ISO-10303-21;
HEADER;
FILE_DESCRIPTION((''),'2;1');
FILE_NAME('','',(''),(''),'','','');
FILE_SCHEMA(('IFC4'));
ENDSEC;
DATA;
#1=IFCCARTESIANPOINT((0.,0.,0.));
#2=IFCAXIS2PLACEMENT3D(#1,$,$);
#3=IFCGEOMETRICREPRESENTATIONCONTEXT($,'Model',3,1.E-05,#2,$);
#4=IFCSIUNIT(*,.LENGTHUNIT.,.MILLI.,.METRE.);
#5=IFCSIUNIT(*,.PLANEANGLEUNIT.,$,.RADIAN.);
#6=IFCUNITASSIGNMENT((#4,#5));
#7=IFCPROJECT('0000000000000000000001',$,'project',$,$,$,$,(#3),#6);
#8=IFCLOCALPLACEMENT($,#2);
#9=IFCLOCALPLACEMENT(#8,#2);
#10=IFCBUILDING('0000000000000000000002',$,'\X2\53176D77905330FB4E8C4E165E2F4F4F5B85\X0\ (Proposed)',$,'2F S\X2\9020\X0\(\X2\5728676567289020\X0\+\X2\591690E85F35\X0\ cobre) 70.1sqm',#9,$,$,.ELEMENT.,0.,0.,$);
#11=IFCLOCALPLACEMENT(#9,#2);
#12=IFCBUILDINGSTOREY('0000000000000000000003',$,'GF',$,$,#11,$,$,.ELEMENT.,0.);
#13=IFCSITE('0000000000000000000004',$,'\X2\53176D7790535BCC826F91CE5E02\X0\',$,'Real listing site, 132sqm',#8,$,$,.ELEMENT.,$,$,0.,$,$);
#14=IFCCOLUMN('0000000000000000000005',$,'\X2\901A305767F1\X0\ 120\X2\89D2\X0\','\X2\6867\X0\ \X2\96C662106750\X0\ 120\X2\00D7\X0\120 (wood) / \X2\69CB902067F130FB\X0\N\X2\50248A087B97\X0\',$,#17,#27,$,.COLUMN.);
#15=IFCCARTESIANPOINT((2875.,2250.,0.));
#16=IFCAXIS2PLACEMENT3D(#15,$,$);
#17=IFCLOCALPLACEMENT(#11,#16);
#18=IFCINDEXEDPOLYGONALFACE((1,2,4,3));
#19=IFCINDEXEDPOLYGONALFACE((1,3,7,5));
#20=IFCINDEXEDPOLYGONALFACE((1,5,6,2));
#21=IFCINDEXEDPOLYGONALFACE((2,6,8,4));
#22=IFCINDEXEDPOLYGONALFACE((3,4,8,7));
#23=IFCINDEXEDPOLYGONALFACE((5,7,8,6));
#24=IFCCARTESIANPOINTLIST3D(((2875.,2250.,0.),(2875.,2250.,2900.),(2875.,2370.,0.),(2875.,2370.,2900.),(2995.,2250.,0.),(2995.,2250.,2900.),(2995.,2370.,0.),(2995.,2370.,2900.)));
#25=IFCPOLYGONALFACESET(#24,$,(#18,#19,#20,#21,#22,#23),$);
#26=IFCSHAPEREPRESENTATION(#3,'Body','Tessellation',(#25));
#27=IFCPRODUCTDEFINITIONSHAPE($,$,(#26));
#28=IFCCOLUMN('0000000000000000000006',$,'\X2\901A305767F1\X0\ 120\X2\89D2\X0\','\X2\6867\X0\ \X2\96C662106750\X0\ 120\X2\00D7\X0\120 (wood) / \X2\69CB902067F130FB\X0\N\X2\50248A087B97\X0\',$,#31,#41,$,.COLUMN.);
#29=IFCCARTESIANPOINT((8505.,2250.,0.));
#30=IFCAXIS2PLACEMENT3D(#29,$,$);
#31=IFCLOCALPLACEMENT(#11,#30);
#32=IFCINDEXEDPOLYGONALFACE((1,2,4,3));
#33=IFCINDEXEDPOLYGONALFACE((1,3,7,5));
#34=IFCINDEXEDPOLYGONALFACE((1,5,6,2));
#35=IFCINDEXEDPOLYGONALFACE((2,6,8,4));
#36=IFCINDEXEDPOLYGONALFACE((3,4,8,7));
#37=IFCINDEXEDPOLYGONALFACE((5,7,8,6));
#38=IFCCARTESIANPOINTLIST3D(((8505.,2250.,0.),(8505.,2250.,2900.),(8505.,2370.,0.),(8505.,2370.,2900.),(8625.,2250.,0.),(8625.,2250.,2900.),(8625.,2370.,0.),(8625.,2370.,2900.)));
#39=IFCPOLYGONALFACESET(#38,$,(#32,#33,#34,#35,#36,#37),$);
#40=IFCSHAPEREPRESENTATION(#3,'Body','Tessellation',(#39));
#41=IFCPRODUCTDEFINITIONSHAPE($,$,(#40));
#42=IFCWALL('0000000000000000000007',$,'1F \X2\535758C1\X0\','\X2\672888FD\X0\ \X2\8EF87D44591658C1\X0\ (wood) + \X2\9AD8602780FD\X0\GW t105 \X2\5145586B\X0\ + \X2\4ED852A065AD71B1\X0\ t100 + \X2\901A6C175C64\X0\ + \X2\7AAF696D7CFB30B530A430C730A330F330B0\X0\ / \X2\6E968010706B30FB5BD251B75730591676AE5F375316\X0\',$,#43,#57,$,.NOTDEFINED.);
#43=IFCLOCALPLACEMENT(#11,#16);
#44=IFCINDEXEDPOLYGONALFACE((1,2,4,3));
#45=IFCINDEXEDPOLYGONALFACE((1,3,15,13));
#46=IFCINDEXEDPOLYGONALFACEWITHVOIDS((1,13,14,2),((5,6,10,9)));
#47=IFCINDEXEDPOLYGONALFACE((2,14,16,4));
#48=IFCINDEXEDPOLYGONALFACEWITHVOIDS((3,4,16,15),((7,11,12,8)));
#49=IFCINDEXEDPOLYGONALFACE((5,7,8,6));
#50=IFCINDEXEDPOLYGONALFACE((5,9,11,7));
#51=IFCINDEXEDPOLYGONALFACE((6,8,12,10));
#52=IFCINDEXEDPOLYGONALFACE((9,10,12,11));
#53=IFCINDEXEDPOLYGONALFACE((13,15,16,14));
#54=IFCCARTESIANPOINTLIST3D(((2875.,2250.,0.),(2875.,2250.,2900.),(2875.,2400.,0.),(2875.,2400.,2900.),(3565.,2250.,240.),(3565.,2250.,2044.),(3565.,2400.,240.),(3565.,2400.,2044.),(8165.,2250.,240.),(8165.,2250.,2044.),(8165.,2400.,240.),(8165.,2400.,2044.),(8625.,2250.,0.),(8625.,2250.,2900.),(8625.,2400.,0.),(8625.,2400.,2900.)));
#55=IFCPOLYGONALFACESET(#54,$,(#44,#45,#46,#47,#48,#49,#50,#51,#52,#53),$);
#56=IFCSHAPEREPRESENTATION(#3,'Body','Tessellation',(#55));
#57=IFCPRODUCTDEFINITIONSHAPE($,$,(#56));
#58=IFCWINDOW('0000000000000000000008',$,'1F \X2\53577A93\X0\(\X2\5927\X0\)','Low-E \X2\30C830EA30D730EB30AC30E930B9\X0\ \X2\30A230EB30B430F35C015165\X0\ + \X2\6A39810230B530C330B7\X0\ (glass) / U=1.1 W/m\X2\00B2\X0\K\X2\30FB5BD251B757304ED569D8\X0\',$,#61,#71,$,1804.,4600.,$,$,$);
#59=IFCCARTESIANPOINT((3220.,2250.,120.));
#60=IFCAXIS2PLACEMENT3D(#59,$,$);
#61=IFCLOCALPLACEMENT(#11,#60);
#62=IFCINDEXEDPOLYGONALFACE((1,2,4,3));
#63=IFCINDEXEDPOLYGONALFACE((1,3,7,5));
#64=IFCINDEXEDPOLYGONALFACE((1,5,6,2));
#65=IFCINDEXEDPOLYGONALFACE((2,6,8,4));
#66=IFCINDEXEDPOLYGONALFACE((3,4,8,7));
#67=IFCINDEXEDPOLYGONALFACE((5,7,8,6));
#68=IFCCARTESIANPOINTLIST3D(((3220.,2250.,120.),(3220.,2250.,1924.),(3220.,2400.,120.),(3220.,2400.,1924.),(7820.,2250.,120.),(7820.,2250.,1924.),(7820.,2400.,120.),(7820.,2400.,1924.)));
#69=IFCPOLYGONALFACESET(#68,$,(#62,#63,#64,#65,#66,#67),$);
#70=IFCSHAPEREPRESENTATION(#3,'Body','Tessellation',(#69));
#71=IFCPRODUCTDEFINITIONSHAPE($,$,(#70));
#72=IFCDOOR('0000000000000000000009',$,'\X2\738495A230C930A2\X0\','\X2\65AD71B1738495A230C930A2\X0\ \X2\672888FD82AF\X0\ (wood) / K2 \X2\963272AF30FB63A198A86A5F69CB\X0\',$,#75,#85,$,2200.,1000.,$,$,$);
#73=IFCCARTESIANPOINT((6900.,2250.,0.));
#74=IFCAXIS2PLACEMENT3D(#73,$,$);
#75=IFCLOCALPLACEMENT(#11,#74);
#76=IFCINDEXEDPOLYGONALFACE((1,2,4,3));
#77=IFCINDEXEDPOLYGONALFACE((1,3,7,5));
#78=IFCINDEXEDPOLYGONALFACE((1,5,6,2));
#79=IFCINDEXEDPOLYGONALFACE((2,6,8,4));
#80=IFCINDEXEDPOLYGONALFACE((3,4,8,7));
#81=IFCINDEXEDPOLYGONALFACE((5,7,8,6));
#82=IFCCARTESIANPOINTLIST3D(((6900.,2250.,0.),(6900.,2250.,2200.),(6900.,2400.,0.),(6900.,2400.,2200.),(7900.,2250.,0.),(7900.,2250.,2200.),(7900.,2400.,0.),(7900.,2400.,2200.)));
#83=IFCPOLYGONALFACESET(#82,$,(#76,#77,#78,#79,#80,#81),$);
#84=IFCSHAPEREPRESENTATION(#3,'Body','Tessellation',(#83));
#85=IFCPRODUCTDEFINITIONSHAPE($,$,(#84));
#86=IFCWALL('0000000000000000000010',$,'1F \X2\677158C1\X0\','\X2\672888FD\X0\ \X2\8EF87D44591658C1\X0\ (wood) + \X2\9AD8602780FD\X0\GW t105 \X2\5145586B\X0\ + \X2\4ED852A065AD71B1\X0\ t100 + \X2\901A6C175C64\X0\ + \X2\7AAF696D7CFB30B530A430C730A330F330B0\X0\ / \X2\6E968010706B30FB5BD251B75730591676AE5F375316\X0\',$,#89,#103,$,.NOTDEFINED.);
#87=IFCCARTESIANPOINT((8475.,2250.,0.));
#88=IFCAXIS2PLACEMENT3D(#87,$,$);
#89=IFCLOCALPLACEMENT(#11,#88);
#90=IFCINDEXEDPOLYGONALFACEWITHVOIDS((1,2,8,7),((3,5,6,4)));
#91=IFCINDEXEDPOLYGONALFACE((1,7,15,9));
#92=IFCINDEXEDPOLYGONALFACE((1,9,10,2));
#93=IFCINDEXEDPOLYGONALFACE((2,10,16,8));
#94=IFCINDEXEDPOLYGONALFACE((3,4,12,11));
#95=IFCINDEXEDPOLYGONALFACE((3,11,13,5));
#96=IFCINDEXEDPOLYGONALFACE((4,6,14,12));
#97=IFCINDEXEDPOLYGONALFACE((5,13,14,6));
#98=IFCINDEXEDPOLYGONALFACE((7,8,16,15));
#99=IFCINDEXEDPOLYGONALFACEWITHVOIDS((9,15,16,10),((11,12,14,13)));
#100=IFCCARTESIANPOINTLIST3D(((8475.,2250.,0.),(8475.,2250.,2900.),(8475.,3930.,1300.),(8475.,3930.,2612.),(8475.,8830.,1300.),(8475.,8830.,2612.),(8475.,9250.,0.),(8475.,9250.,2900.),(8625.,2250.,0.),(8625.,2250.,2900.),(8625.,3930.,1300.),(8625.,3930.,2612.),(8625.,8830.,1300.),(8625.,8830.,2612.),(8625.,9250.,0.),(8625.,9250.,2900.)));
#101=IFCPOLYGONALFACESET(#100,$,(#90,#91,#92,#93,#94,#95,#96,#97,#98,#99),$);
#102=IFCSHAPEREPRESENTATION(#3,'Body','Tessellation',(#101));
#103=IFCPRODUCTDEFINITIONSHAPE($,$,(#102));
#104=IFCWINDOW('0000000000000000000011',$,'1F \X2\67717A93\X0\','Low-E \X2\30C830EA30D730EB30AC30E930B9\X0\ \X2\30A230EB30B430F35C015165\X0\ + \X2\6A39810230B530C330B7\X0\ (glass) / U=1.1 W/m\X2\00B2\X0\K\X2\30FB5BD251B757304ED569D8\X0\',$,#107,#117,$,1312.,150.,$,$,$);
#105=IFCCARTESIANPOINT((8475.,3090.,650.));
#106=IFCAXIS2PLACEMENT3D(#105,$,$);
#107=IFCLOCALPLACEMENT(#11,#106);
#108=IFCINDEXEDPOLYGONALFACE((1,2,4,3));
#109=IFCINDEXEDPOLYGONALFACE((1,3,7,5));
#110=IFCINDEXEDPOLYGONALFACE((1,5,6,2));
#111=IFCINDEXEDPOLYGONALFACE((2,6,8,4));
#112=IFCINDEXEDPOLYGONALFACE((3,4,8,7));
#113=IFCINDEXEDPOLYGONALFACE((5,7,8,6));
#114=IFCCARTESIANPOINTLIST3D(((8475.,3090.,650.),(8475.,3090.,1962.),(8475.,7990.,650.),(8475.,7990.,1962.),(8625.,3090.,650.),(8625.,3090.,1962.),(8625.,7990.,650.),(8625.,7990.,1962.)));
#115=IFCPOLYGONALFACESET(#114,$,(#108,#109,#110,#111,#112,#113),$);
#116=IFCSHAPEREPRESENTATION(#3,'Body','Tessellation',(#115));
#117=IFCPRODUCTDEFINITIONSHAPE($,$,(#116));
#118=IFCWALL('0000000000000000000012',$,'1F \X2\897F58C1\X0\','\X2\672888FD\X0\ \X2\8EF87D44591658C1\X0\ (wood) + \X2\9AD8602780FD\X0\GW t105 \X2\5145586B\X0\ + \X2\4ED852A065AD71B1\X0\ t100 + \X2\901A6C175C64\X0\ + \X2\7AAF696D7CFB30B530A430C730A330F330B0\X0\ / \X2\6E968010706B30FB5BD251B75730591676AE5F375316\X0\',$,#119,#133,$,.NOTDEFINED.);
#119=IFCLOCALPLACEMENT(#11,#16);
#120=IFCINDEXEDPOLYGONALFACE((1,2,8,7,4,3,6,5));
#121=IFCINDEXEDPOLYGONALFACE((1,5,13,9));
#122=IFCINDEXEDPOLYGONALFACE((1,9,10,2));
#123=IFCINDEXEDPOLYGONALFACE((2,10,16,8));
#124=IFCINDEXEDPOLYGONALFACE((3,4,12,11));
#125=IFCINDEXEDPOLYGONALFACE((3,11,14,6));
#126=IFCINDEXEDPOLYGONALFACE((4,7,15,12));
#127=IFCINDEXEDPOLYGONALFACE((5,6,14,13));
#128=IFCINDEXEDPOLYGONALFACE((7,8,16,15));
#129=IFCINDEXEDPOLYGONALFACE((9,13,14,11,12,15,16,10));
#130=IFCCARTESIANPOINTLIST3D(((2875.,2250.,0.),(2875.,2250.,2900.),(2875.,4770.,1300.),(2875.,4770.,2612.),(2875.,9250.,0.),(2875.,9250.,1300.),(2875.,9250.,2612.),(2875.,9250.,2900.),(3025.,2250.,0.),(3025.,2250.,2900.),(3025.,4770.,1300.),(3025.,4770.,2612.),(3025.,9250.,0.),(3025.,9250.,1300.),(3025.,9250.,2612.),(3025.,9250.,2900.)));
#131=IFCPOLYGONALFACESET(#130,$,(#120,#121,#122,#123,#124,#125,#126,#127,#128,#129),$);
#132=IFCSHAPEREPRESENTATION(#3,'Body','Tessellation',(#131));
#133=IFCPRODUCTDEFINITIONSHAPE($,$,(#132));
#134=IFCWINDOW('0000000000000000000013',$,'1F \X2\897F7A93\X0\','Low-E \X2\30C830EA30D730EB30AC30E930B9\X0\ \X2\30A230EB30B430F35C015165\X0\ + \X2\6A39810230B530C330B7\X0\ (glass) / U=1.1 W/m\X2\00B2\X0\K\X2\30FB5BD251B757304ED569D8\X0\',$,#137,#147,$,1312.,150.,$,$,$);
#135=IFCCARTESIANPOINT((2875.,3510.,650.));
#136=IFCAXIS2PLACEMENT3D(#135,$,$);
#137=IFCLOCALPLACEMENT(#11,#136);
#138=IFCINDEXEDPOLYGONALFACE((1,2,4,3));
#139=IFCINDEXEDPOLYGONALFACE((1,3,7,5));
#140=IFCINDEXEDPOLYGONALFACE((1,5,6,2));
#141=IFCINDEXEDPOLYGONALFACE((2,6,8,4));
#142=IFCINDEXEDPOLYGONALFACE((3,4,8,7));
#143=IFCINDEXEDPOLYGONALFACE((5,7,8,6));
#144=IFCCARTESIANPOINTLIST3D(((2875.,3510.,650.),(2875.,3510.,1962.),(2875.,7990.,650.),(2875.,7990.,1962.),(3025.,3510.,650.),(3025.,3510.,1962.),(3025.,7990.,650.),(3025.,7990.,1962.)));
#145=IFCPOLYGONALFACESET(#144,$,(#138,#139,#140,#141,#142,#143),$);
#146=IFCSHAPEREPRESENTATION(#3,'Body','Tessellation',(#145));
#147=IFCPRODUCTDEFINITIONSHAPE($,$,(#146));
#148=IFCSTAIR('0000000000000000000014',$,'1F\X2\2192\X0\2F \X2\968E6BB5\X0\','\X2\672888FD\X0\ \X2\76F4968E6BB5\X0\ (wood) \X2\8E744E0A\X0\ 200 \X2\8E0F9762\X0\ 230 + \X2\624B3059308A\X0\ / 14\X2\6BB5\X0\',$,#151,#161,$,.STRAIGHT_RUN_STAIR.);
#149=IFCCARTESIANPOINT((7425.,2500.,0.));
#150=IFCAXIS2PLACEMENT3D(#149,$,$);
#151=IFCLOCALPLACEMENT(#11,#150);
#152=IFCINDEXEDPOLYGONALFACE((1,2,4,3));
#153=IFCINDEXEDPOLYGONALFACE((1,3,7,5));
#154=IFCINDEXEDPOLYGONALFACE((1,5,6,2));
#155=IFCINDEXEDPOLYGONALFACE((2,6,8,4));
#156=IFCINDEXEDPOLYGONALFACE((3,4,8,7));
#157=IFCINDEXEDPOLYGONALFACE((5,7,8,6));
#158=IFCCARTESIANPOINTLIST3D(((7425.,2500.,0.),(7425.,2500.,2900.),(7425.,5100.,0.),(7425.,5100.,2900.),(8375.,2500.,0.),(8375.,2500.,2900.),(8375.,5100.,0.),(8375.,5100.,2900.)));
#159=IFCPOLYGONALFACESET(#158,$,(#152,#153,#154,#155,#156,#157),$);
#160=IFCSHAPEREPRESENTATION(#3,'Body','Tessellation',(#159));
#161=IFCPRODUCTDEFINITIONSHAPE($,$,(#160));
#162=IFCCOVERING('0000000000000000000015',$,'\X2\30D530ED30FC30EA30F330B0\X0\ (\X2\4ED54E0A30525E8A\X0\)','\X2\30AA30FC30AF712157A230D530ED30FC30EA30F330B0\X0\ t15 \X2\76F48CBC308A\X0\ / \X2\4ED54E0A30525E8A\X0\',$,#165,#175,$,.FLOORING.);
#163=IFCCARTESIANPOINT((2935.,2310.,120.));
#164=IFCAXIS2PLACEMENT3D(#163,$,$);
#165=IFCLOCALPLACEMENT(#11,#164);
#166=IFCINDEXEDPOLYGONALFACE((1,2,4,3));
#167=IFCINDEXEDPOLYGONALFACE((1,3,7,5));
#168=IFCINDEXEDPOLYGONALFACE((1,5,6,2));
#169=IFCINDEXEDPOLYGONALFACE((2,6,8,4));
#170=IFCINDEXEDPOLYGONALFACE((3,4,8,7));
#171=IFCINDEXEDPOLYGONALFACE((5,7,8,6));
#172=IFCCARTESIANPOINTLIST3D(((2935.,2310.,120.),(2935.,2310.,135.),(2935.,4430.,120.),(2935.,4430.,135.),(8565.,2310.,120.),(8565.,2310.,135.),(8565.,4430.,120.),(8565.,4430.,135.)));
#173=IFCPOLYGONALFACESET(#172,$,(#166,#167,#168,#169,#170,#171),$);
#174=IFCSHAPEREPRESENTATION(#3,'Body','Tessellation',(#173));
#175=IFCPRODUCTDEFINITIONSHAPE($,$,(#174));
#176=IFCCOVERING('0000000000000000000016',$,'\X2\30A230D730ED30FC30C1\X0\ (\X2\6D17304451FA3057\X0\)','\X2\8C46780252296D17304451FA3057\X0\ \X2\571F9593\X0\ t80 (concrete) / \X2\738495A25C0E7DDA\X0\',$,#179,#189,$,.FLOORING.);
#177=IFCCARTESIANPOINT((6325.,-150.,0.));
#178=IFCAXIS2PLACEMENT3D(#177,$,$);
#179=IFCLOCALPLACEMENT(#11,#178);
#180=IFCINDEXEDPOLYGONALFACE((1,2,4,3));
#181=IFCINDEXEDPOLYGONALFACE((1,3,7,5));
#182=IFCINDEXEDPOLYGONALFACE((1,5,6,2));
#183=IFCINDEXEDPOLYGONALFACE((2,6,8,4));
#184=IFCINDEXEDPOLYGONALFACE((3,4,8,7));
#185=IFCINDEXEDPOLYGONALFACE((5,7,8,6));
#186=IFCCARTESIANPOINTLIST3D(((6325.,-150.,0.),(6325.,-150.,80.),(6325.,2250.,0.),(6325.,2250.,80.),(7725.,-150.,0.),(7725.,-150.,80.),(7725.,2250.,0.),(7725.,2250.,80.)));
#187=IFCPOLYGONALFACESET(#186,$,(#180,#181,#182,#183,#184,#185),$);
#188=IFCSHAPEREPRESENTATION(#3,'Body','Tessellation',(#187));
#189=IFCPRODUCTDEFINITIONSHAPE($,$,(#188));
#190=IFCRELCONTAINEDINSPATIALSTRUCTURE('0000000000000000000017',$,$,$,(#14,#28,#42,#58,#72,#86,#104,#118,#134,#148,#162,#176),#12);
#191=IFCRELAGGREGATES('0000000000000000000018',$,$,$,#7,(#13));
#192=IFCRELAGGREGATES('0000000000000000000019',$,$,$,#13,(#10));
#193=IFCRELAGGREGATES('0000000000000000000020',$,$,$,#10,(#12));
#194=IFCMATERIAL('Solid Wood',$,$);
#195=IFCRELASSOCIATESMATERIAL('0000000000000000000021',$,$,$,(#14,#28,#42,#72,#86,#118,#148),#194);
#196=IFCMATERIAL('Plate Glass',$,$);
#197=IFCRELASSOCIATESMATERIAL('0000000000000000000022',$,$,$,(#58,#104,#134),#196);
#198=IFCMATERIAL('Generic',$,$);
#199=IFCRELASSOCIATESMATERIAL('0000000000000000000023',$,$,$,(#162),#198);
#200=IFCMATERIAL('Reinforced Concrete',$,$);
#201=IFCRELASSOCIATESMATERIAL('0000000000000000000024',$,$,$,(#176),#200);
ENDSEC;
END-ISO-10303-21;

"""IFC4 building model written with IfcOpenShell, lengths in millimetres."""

from ifc_helpers import new_model, si_unit, frame, frame_2d, origin, place, context, project, spatial, rectangle, extrude, material, element, fill, save


model = new_model("IFC4")

# Units and contexts
model_context = context("Model", 3, precision=1e-05, world=origin())
ifc_project = project(units=[si_unit("LENGTHUNIT", "METRE", prefix="MILLI"), si_unit("PLANEANGLEUNIT", "RADIAN")], contexts=[model_context])

# Site, building, storey
site_placement = place(None, origin())
site = spatial("IfcSite", under=ifc_project, at=site_placement, Name="北海道富良野市", ObjectType="Real listing site, 132sqm", CompositionType="ELEMENT", RefElevation=0.0)
building_placement = place(site_placement, origin())
building = spatial("IfcBuilding", under=site, at=building_placement, Name="北海道・二世帯住宅 (Proposed)", ObjectType="2F S造(在来木造+外部張 cobre) 70.1sqm", CompositionType="ELEMENT", ElevationOfRefHeight=0.0, ElevationOfTerrain=0.0)
storey_placement = place(building_placement, origin())
storey = spatial("IfcBuildingStorey", under=building, at=storey_placement, Name="GF", CompositionType="ELEMENT", Elevation=0.0)

# Columns
ifc_material_1 = material(Name="Solid Wood")
column_1_placement = place(storey_placement, frame((2875.0, 2250.0, 0.0)))
element("IfcColumn", 1, at=column_1_placement, inside=storey, material=ifc_material_1, Name="通し柱 120角", Description="桧 集成材 120×120 (wood) / 構造柱・N値計算", PredefinedType="COLUMN", context=model_context, shape_type="SweptSolid", body=[
    extrude(rectangle(XDim=120.0, YDim=120.0, at=frame_2d((60.0, 60.0))), frame((2875.0, 2250.0, 0.0)), (0.0, 0.0, 1.0), 2900.0),
])
column_2_placement = place(storey_placement, frame((8505.0, 2250.0, 0.0)))
element("IfcColumn", 2, at=column_2_placement, inside=storey, material=ifc_material_1, Name="通し柱 120角", Description="桧 集成材 120×120 (wood) / 構造柱・N値計算", PredefinedType="COLUMN", context=model_context, shape_type="SweptSolid", body=[
    extrude(rectangle(XDim=120.0, YDim=120.0, at=frame_2d((60.0, 60.0))), frame((8505.0, 2250.0, 0.0)), (0.0, 0.0, 1.0), 2900.0),
])

# Shared definitions
ifc_material_2 = material(Name="Reinforced Concrete")

# Wall, openings, window, door
wall_1_placement = place(storey_placement, frame((2875.0, 2250.0, 0.0)))
wall_1 = element("IfcWall", 3, at=wall_1_placement, inside=storey, material=ifc_material_1, Name="1F 南壁", Description="木製 軸組外壁 (wood) + 高性能GW t105 充填 + 付加断熱 t100 + 通気層 + 窯業系サイディング / 準耐火・寒冷地外皮強化", PredefinedType="NOTDEFINED", context=model_context, shape_type="SweptSolid", body=[
    extrude(rectangle(XDim=5750.0, YDim=150.0, at=frame_2d((2875.0, 75.0))), frame((2875.0, 2250.0, 0.0)), (0.0, 0.0, 1.0), 2900.0),
])
opening_1_placement = place(storey_placement, frame((3220.0, 2250.0, 120.0)))
opening_1 = element("IfcOpeningElement", 4, at=opening_1_placement, cuts=wall_1, PredefinedType="NOTDEFINED", context=model_context, shape_type="SweptSolid", body=[
    extrude(rectangle(XDim=4600.0, YDim=150.0, at=frame_2d((2300.0, 75.0))), frame((3220.0, 2250.0, 120.0)), (0.0, 0.0, 1.0), 1804.0),
])
opening_2_placement = place(storey_placement, frame((6900.0, 2250.0, 0.0)))
opening_2 = element("IfcOpeningElement", 5, at=opening_2_placement, cuts=wall_1, PredefinedType="NOTDEFINED", context=model_context, shape_type="SweptSolid", body=[
    extrude(rectangle(XDim=1000.0, YDim=150.0, at=frame_2d((500.0, 75.0))), frame((6900.0, 2250.0, 0.0)), (0.0, 0.0, 1.0), 2200.0),
])
ifc_material_3 = material(Name="Plate Glass")
window_1_placement = place(storey_placement, frame((3220.0, 2250.0, 120.0)))
window_1 = element("IfcWindow", 6, at=window_1_placement, inside=storey, material=ifc_material_3, Name="1F 南窓(大)", Description="Low-E トリプルガラス アルゴン封入 + 樹脂サッシ (glass) / U=1.1 W/m²K・寒冷地仕様", OverallHeight=1804.0, OverallWidth=4600.0, context=model_context, shape_type="SweptSolid", body=[
    extrude(rectangle(XDim=4600.0, YDim=150.0, at=frame_2d((2300.0, 75.0))), frame((3220.0, 2250.0, 120.0)), (0.0, 0.0, 1.0), 1804.0),
])
fill(opening_1, window_1)
door_placement = place(storey_placement, frame((6900.0, 2250.0, 0.0)))
door = element("IfcDoor", 7, at=door_placement, inside=storey, material=ifc_material_1, Name="玄関ドア", Description="断熱玄関ドア 木製芯 (wood) / K2 防犯・採風機構", OverallHeight=2200.0, OverallWidth=1000.0, context=model_context, shape_type="SweptSolid", body=[
    extrude(rectangle(XDim=1000.0, YDim=150.0, at=frame_2d((500.0, 75.0))), frame((6900.0, 2250.0, 0.0)), (0.0, 0.0, 1.0), 2200.0),
])
fill(opening_2, door)

# Walls, openings, windows
wall_2_placement = place(storey_placement, frame((8475.0, 2250.0, 0.0)))
wall_2 = element("IfcWall", 8, at=wall_2_placement, inside=storey, material=ifc_material_1, Name="1F 東壁", Description="木製 軸組外壁 (wood) + 高性能GW t105 充填 + 付加断熱 t100 + 通気層 + 窯業系サイディング / 準耐火・寒冷地外皮強化", PredefinedType="NOTDEFINED", context=model_context, shape_type="SweptSolid", body=[
    extrude(rectangle(XDim=150.0, YDim=7000.0, at=frame_2d((75.0, 3500.0))), frame((8475.0, 2250.0, 0.0)), (0.0, 0.0, 1.0), 2900.0),
])
opening_3_placement = place(storey_placement, frame((8475.0, 3090.0, 650.0)))
opening_3 = element("IfcOpeningElement", 9, at=opening_3_placement, cuts=wall_2, PredefinedType="NOTDEFINED", context=model_context, shape_type="SweptSolid", body=[
    extrude(rectangle(XDim=150.0, YDim=4900.0, at=frame_2d((75.0, 2450.0))), frame((8475.0, 3090.0, 650.0)), (0.0, 0.0, 1.0), 1312.0),
])
window_2_placement = place(storey_placement, frame((8475.0, 3090.0, 650.0)))
window_2 = element("IfcWindow", 10, at=window_2_placement, inside=storey, material=ifc_material_3, Name="1F 東窓", Description="Low-E トリプルガラス アルゴン封入 + 樹脂サッシ (glass) / U=1.1 W/m²K・寒冷地仕様", OverallHeight=1312.0, OverallWidth=150.0, context=model_context, shape_type="SweptSolid", body=[
    extrude(rectangle(XDim=150.0, YDim=4900.0, at=frame_2d((75.0, 2450.0))), frame((8475.0, 3090.0, 650.0)), (0.0, 0.0, 1.0), 1312.0),
])
fill(opening_3, window_2)
wall_3_placement = place(storey_placement, frame((2875.0, 2250.0, 0.0)))
wall_3 = element("IfcWall", 11, at=wall_3_placement, inside=storey, material=ifc_material_1, Name="1F 西壁", Description="木製 軸組外壁 (wood) + 高性能GW t105 充填 + 付加断熱 t100 + 通気層 + 窯業系サイディング / 準耐火・寒冷地外皮強化", PredefinedType="NOTDEFINED", context=model_context, shape_type="SweptSolid", body=[
    extrude(rectangle(XDim=150.0, YDim=7000.0, at=frame_2d((75.0, 3500.0))), frame((2875.0, 2250.0, 0.0)), (0.0, 0.0, 1.0), 2900.0),
])
opening_4_placement = place(storey_placement, frame((2875.0, 3510.0, 650.0)))
opening_4 = element("IfcOpeningElement", 12, at=opening_4_placement, cuts=wall_3, PredefinedType="NOTDEFINED", context=model_context, shape_type="SweptSolid", body=[
    extrude(rectangle(XDim=150.0, YDim=4480.0, at=frame_2d((75.0, 2240.0))), frame((2875.0, 3510.0, 650.0)), (0.0, 0.0, 1.0), 1312.0),
])
window_3_placement = place(storey_placement, frame((2875.0, 3510.0, 650.0)))
window_3 = element("IfcWindow", 13, at=window_3_placement, inside=storey, material=ifc_material_3, Name="1F 西窓", Description="Low-E トリプルガラス アルゴン封入 + 樹脂サッシ (glass) / U=1.1 W/m²K・寒冷地仕様", OverallHeight=1312.0, OverallWidth=150.0, context=model_context, shape_type="SweptSolid", body=[
    extrude(rectangle(XDim=150.0, YDim=4480.0, at=frame_2d((75.0, 2240.0))), frame((2875.0, 3510.0, 650.0)), (0.0, 0.0, 1.0), 1312.0),
])
fill(opening_4, window_3)

# Stair
stair_placement = place(storey_placement, frame((7425.0, 2500.0, 0.0)))
element("IfcStair", 14, at=stair_placement, inside=storey, material=ifc_material_1, Name="1F→2F 階段", Description="木製 直階段 (wood) 蹴上 200 踏面 230 + 手すり / 14段", PredefinedType="STRAIGHT_RUN_STAIR", context=model_context, shape_type="SweptSolid", body=[
    extrude(rectangle(XDim=950.0, YDim=2600.0, at=frame_2d((475.0, 1300.0))), frame((7425.0, 2500.0, 0.0)), (0.0, 0.0, 1.0), 2900.0),
])

# Coverings
ifc_material_4 = material(Name="Generic")
covering_1_placement = place(storey_placement, frame((2935.0, 2310.0, 120.0)))
element("IfcCovering", 15, at=covering_1_placement, inside=storey, material=ifc_material_4, Name="フローリング (仕上げ床)", Description="オーク無垢フローリング t15 直貼り / 仕上げ床", PredefinedType="FLOORING", context=model_context, shape_type="SweptSolid", body=[
    extrude(rectangle(XDim=5630.0, YDim=2120.0, at=frame_2d((2815.0, 1060.0))), frame((2935.0, 2310.0, 120.0)), (0.0, 0.0, 1.0), 15.0),
])
covering_2_placement = place(storey_placement, frame((6325.0, -150.0, 0.0)))
element("IfcCovering", 16, at=covering_2_placement, inside=storey, material=ifc_material_2, Name="アプローチ (洗い出し)", Description="豆砂利洗い出し 土間 t80 (concrete) / 玄関導線", PredefinedType="FLOORING", context=model_context, shape_type="SweptSolid", body=[
    extrude(rectangle(XDim=1400.0, YDim=2400.0, at=frame_2d((700.0, 1200.0))), frame((6325.0, -150.0, 0.0)), (0.0, 0.0, 1.0), 80.0),
])

save(model, "model.ifc")
